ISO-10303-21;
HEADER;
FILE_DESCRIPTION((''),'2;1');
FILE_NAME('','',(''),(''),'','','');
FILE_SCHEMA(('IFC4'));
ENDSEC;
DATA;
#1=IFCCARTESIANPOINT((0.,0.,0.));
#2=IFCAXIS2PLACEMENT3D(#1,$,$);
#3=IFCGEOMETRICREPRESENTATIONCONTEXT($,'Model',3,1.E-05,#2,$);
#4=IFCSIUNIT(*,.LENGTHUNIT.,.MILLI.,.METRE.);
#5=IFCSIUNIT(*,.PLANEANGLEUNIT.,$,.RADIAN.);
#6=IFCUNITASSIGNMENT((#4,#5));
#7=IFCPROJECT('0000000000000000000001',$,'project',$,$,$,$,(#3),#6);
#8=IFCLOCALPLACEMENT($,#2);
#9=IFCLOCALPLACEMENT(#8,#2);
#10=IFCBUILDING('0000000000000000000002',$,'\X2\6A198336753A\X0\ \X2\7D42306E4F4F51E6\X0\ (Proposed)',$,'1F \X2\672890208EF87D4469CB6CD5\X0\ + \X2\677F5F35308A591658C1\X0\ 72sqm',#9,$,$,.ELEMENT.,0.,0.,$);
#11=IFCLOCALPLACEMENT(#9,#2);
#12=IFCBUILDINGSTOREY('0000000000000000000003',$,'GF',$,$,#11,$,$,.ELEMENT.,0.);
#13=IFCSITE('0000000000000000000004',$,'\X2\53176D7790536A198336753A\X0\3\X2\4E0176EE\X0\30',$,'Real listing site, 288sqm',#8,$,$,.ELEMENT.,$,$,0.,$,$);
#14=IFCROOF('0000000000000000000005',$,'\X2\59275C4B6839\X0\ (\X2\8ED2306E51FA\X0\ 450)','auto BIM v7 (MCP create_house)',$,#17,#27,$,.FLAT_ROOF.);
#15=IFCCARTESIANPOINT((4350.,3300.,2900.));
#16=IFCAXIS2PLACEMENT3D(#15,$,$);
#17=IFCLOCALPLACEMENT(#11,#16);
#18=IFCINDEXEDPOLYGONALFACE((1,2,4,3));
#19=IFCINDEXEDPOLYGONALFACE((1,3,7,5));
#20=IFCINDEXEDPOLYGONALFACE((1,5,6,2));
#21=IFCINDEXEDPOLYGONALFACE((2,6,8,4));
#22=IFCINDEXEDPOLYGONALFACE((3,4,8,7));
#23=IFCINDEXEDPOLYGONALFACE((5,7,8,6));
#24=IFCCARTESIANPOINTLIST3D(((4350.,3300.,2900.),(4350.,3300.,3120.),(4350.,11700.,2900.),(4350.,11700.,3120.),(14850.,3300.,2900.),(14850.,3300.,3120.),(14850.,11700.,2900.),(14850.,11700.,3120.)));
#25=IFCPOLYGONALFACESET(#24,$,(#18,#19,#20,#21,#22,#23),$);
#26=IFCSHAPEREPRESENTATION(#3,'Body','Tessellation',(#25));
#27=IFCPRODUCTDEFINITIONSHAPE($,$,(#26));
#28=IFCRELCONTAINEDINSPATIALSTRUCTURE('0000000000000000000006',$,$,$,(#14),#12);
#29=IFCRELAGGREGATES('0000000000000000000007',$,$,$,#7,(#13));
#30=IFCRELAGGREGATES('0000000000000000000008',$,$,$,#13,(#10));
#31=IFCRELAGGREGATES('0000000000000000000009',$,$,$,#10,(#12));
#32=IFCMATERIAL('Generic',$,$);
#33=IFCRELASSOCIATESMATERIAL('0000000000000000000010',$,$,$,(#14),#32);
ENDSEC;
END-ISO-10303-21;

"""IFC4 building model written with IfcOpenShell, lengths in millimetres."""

from ifc_helpers import new_model, si_unit, frame, frame_2d, origin, place, context, project, spatial, rectangle, extrude, material, element, save


model = new_model("IFC4")

# Units and contexts
model_context = context("Model", 3, precision=1e-05, world=origin())
ifc_project = project(units=[si_unit("LENGTHUNIT", "METRE", prefix="MILLI"), si_unit("PLANEANGLEUNIT", "RADIAN")], contexts=[model_context])

# Site, building, storey
site_placement = place(None, origin())
site = spatial("IfcSite", under=ifc_project, at=site_placement, Name="北海道標茶町3丁目30", ObjectType="Real listing site, 288sqm", CompositionType="ELEMENT", RefElevation=0.0)
building_placement = place(site_placement, origin())
building = spatial("IfcBuilding", under=site, at=building_placement, Name="標茶町 終の住処 (Proposed)", ObjectType="1F 木造軸組構法 + 板張り外壁 72sqm", CompositionType="ELEMENT", ElevationOfRefHeight=0.0, ElevationOfTerrain=0.0)
storey_placement = place(building_placement, origin())
storey = spatial("IfcBuildingStorey", under=building, at=storey_placement, Name="GF", CompositionType="ELEMENT", Elevation=0.0)

# Shared definitions
ifc_material = material(Name="Generic")

# Roof
roof_placement = place(storey_placement, frame((4350.0, 3300.0, 2900.0)))
element("IfcRoof", 1, at=roof_placement, inside=storey, material=ifc_material, Name="大屋根 (軒の出 450)", Description="auto BIM v7 (MCP create_house)", PredefinedType="FLAT_ROOF", context=model_context, shape_type="SweptSolid", body=[
    extrude(rectangle(XDim=10500.0, YDim=8400.0, at=frame_2d((5250.0, 4200.0))), frame((4350.0, 3300.0, 2900.0)), (0.0, 0.0, 1.0), 220.0),
])

save(model, "model.ifc")
